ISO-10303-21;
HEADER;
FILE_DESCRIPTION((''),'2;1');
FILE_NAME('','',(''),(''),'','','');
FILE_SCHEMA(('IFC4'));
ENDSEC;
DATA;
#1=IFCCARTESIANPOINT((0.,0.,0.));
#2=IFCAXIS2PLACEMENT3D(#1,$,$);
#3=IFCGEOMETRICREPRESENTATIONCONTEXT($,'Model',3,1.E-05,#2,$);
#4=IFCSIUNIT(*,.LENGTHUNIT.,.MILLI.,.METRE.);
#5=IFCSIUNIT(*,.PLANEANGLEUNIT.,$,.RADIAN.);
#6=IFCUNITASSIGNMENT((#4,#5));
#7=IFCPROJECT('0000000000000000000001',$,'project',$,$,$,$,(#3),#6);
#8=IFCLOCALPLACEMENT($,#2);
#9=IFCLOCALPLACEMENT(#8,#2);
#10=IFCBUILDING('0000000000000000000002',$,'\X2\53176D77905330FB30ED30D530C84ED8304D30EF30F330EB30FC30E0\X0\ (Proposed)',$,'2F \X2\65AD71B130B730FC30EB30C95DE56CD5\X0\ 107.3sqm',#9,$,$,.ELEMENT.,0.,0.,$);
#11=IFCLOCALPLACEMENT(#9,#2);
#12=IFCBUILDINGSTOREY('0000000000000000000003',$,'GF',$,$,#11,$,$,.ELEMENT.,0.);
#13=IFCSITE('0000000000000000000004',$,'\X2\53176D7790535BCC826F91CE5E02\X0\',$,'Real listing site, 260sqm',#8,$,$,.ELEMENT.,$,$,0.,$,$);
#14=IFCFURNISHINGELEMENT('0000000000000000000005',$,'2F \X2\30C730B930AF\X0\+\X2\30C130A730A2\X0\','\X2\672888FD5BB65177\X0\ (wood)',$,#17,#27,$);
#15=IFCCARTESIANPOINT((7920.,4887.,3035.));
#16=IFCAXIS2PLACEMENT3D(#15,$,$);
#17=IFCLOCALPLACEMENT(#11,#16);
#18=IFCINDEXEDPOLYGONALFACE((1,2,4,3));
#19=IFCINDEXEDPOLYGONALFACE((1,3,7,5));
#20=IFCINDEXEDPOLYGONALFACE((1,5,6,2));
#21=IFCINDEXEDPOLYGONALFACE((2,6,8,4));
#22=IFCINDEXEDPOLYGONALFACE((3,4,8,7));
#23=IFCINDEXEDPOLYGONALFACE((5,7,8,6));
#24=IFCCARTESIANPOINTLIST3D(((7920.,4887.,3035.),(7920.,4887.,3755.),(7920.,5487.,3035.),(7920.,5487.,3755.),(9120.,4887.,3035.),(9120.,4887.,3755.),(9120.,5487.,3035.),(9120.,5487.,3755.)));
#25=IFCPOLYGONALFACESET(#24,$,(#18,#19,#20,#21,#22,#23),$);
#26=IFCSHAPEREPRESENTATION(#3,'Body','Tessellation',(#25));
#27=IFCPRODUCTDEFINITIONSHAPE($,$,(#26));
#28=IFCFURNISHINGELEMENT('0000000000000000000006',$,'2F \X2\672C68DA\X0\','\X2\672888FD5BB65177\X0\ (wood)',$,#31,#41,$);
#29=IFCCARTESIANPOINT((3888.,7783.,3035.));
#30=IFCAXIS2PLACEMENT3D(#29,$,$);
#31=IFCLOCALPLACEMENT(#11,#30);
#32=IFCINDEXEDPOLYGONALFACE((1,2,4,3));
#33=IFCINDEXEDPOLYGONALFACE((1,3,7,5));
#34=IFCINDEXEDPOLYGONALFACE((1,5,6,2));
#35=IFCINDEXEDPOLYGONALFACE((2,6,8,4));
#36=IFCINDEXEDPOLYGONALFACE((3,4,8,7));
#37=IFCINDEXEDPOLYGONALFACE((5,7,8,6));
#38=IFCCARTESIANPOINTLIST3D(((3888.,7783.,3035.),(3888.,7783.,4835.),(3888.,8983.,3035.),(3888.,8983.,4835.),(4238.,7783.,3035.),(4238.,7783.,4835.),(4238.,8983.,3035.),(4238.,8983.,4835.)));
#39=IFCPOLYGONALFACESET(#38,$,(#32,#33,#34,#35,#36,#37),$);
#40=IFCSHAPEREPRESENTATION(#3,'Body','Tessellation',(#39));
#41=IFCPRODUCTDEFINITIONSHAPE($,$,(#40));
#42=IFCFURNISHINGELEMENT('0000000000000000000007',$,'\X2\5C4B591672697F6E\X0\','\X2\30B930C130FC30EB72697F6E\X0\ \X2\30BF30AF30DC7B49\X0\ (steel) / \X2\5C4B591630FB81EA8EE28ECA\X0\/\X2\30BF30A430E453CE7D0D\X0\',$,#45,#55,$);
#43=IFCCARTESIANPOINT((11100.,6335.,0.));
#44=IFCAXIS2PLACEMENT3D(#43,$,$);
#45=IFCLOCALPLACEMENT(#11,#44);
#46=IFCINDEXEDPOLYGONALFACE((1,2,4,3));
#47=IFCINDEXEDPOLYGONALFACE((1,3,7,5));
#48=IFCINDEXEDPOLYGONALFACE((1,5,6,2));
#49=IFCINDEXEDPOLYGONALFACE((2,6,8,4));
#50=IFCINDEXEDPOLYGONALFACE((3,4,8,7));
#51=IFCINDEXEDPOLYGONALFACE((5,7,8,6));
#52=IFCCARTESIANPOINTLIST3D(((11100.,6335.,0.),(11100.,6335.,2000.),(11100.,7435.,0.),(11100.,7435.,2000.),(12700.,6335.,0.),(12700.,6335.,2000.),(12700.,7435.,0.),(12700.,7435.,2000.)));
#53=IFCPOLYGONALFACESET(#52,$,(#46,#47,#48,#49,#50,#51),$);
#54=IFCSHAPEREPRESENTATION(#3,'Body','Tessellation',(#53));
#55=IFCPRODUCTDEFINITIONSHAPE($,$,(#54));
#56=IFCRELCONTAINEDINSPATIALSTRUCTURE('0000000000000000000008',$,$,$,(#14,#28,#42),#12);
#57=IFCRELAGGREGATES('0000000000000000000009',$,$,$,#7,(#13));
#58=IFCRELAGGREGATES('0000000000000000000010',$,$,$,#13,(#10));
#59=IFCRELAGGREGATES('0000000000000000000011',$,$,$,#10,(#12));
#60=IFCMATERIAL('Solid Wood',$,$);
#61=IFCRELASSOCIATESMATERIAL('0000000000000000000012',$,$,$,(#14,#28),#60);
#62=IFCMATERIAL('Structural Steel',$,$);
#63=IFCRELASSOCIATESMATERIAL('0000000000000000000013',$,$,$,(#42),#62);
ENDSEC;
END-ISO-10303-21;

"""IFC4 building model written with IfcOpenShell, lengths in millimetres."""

from ifc_helpers import new_model, si_unit, frame, frame_2d, origin, place, context, project, spatial, rectangle, extrude, material, element, save


model = new_model("IFC4")

# Units and contexts
model_context = context("Model", 3, precision=1e-05, world=origin())
ifc_project = project(units=[si_unit("LENGTHUNIT", "METRE", prefix="MILLI"), si_unit("PLANEANGLEUNIT", "RADIAN")], contexts=[model_context])

# Site, building, storey
site_placement = place(None, origin())
site = spatial("IfcSite", under=ifc_project, at=site_placement, Name="北海道富良野市", ObjectType="Real listing site, 260sqm", CompositionType="ELEMENT", RefElevation=0.0)
building_placement = place(site_placement, origin())
building = spatial("IfcBuilding", under=site, at=building_placement, Name="北海道・ロフト付きワンルーム (Proposed)", ObjectType="2F 断熱シールド工法 107.3sqm", CompositionType="ELEMENT", ElevationOfRefHeight=0.0, ElevationOfTerrain=0.0)
storey_placement = place(building_placement, origin())
storey = spatial("IfcBuildingStorey", under=building, at=storey_placement, Name="GF", CompositionType="ELEMENT", Elevation=0.0)

# Shared definitions
ifc_material_1 = material(Name="Solid Wood")

# Shared definitions
ifc_material_2 = material(Name="Structural Steel")

# Furnishing elements
furnishing_1_placement = place(storey_placement, frame((7920.0, 4887.0, 3035.0)))
element("IfcFurnishingElement", 1, at=furnishing_1_placement, inside=storey, material=ifc_material_1, Name="2F デスク+チェア", Description="木製家具 (wood)", context=model_context, shape_type="SweptSolid", body=[
    extrude(rectangle(XDim=1200.0, YDim=600.0, at=frame_2d((600.0, 300.0))), frame((7920.0, 4887.0, 3035.0)), (0.0, 0.0, 1.0), 720.0),
])
furnishing_2_placement = place(storey_placement, frame((3888.0, 7783.0, 3035.0)))
element("IfcFurnishingElement", 2, at=furnishing_2_placement, inside=storey, material=ifc_material_1, Name="2F 本棚", Description="木製家具 (wood)", context=model_context, shape_type="SweptSolid", body=[
    extrude(rectangle(XDim=350.0, YDim=1200.0, at=frame_2d((175.0, 600.0))), frame((3888.0, 7783.0, 3035.0)), (0.0, 0.0, 1.0), 1800.0),
])
furnishing_3_placement = place(storey_placement, frame((11100.0, 6335.0, 0.0)))
element("IfcFurnishingElement", 3, at=furnishing_3_placement, inside=storey, material=ifc_material_2, Name="屋外物置", Description="スチール物置 タクボ等 (steel) / 屋外・自転車/タイヤ収納", context=model_context, shape_type="SweptSolid", body=[
    extrude(rectangle(XDim=1600.0, YDim=1100.0, at=frame_2d((800.0, 550.0))), frame((11100.0, 6335.0, 0.0)), (0.0, 0.0, 1.0), 2000.0),
])

save(model, "model.ifc")
